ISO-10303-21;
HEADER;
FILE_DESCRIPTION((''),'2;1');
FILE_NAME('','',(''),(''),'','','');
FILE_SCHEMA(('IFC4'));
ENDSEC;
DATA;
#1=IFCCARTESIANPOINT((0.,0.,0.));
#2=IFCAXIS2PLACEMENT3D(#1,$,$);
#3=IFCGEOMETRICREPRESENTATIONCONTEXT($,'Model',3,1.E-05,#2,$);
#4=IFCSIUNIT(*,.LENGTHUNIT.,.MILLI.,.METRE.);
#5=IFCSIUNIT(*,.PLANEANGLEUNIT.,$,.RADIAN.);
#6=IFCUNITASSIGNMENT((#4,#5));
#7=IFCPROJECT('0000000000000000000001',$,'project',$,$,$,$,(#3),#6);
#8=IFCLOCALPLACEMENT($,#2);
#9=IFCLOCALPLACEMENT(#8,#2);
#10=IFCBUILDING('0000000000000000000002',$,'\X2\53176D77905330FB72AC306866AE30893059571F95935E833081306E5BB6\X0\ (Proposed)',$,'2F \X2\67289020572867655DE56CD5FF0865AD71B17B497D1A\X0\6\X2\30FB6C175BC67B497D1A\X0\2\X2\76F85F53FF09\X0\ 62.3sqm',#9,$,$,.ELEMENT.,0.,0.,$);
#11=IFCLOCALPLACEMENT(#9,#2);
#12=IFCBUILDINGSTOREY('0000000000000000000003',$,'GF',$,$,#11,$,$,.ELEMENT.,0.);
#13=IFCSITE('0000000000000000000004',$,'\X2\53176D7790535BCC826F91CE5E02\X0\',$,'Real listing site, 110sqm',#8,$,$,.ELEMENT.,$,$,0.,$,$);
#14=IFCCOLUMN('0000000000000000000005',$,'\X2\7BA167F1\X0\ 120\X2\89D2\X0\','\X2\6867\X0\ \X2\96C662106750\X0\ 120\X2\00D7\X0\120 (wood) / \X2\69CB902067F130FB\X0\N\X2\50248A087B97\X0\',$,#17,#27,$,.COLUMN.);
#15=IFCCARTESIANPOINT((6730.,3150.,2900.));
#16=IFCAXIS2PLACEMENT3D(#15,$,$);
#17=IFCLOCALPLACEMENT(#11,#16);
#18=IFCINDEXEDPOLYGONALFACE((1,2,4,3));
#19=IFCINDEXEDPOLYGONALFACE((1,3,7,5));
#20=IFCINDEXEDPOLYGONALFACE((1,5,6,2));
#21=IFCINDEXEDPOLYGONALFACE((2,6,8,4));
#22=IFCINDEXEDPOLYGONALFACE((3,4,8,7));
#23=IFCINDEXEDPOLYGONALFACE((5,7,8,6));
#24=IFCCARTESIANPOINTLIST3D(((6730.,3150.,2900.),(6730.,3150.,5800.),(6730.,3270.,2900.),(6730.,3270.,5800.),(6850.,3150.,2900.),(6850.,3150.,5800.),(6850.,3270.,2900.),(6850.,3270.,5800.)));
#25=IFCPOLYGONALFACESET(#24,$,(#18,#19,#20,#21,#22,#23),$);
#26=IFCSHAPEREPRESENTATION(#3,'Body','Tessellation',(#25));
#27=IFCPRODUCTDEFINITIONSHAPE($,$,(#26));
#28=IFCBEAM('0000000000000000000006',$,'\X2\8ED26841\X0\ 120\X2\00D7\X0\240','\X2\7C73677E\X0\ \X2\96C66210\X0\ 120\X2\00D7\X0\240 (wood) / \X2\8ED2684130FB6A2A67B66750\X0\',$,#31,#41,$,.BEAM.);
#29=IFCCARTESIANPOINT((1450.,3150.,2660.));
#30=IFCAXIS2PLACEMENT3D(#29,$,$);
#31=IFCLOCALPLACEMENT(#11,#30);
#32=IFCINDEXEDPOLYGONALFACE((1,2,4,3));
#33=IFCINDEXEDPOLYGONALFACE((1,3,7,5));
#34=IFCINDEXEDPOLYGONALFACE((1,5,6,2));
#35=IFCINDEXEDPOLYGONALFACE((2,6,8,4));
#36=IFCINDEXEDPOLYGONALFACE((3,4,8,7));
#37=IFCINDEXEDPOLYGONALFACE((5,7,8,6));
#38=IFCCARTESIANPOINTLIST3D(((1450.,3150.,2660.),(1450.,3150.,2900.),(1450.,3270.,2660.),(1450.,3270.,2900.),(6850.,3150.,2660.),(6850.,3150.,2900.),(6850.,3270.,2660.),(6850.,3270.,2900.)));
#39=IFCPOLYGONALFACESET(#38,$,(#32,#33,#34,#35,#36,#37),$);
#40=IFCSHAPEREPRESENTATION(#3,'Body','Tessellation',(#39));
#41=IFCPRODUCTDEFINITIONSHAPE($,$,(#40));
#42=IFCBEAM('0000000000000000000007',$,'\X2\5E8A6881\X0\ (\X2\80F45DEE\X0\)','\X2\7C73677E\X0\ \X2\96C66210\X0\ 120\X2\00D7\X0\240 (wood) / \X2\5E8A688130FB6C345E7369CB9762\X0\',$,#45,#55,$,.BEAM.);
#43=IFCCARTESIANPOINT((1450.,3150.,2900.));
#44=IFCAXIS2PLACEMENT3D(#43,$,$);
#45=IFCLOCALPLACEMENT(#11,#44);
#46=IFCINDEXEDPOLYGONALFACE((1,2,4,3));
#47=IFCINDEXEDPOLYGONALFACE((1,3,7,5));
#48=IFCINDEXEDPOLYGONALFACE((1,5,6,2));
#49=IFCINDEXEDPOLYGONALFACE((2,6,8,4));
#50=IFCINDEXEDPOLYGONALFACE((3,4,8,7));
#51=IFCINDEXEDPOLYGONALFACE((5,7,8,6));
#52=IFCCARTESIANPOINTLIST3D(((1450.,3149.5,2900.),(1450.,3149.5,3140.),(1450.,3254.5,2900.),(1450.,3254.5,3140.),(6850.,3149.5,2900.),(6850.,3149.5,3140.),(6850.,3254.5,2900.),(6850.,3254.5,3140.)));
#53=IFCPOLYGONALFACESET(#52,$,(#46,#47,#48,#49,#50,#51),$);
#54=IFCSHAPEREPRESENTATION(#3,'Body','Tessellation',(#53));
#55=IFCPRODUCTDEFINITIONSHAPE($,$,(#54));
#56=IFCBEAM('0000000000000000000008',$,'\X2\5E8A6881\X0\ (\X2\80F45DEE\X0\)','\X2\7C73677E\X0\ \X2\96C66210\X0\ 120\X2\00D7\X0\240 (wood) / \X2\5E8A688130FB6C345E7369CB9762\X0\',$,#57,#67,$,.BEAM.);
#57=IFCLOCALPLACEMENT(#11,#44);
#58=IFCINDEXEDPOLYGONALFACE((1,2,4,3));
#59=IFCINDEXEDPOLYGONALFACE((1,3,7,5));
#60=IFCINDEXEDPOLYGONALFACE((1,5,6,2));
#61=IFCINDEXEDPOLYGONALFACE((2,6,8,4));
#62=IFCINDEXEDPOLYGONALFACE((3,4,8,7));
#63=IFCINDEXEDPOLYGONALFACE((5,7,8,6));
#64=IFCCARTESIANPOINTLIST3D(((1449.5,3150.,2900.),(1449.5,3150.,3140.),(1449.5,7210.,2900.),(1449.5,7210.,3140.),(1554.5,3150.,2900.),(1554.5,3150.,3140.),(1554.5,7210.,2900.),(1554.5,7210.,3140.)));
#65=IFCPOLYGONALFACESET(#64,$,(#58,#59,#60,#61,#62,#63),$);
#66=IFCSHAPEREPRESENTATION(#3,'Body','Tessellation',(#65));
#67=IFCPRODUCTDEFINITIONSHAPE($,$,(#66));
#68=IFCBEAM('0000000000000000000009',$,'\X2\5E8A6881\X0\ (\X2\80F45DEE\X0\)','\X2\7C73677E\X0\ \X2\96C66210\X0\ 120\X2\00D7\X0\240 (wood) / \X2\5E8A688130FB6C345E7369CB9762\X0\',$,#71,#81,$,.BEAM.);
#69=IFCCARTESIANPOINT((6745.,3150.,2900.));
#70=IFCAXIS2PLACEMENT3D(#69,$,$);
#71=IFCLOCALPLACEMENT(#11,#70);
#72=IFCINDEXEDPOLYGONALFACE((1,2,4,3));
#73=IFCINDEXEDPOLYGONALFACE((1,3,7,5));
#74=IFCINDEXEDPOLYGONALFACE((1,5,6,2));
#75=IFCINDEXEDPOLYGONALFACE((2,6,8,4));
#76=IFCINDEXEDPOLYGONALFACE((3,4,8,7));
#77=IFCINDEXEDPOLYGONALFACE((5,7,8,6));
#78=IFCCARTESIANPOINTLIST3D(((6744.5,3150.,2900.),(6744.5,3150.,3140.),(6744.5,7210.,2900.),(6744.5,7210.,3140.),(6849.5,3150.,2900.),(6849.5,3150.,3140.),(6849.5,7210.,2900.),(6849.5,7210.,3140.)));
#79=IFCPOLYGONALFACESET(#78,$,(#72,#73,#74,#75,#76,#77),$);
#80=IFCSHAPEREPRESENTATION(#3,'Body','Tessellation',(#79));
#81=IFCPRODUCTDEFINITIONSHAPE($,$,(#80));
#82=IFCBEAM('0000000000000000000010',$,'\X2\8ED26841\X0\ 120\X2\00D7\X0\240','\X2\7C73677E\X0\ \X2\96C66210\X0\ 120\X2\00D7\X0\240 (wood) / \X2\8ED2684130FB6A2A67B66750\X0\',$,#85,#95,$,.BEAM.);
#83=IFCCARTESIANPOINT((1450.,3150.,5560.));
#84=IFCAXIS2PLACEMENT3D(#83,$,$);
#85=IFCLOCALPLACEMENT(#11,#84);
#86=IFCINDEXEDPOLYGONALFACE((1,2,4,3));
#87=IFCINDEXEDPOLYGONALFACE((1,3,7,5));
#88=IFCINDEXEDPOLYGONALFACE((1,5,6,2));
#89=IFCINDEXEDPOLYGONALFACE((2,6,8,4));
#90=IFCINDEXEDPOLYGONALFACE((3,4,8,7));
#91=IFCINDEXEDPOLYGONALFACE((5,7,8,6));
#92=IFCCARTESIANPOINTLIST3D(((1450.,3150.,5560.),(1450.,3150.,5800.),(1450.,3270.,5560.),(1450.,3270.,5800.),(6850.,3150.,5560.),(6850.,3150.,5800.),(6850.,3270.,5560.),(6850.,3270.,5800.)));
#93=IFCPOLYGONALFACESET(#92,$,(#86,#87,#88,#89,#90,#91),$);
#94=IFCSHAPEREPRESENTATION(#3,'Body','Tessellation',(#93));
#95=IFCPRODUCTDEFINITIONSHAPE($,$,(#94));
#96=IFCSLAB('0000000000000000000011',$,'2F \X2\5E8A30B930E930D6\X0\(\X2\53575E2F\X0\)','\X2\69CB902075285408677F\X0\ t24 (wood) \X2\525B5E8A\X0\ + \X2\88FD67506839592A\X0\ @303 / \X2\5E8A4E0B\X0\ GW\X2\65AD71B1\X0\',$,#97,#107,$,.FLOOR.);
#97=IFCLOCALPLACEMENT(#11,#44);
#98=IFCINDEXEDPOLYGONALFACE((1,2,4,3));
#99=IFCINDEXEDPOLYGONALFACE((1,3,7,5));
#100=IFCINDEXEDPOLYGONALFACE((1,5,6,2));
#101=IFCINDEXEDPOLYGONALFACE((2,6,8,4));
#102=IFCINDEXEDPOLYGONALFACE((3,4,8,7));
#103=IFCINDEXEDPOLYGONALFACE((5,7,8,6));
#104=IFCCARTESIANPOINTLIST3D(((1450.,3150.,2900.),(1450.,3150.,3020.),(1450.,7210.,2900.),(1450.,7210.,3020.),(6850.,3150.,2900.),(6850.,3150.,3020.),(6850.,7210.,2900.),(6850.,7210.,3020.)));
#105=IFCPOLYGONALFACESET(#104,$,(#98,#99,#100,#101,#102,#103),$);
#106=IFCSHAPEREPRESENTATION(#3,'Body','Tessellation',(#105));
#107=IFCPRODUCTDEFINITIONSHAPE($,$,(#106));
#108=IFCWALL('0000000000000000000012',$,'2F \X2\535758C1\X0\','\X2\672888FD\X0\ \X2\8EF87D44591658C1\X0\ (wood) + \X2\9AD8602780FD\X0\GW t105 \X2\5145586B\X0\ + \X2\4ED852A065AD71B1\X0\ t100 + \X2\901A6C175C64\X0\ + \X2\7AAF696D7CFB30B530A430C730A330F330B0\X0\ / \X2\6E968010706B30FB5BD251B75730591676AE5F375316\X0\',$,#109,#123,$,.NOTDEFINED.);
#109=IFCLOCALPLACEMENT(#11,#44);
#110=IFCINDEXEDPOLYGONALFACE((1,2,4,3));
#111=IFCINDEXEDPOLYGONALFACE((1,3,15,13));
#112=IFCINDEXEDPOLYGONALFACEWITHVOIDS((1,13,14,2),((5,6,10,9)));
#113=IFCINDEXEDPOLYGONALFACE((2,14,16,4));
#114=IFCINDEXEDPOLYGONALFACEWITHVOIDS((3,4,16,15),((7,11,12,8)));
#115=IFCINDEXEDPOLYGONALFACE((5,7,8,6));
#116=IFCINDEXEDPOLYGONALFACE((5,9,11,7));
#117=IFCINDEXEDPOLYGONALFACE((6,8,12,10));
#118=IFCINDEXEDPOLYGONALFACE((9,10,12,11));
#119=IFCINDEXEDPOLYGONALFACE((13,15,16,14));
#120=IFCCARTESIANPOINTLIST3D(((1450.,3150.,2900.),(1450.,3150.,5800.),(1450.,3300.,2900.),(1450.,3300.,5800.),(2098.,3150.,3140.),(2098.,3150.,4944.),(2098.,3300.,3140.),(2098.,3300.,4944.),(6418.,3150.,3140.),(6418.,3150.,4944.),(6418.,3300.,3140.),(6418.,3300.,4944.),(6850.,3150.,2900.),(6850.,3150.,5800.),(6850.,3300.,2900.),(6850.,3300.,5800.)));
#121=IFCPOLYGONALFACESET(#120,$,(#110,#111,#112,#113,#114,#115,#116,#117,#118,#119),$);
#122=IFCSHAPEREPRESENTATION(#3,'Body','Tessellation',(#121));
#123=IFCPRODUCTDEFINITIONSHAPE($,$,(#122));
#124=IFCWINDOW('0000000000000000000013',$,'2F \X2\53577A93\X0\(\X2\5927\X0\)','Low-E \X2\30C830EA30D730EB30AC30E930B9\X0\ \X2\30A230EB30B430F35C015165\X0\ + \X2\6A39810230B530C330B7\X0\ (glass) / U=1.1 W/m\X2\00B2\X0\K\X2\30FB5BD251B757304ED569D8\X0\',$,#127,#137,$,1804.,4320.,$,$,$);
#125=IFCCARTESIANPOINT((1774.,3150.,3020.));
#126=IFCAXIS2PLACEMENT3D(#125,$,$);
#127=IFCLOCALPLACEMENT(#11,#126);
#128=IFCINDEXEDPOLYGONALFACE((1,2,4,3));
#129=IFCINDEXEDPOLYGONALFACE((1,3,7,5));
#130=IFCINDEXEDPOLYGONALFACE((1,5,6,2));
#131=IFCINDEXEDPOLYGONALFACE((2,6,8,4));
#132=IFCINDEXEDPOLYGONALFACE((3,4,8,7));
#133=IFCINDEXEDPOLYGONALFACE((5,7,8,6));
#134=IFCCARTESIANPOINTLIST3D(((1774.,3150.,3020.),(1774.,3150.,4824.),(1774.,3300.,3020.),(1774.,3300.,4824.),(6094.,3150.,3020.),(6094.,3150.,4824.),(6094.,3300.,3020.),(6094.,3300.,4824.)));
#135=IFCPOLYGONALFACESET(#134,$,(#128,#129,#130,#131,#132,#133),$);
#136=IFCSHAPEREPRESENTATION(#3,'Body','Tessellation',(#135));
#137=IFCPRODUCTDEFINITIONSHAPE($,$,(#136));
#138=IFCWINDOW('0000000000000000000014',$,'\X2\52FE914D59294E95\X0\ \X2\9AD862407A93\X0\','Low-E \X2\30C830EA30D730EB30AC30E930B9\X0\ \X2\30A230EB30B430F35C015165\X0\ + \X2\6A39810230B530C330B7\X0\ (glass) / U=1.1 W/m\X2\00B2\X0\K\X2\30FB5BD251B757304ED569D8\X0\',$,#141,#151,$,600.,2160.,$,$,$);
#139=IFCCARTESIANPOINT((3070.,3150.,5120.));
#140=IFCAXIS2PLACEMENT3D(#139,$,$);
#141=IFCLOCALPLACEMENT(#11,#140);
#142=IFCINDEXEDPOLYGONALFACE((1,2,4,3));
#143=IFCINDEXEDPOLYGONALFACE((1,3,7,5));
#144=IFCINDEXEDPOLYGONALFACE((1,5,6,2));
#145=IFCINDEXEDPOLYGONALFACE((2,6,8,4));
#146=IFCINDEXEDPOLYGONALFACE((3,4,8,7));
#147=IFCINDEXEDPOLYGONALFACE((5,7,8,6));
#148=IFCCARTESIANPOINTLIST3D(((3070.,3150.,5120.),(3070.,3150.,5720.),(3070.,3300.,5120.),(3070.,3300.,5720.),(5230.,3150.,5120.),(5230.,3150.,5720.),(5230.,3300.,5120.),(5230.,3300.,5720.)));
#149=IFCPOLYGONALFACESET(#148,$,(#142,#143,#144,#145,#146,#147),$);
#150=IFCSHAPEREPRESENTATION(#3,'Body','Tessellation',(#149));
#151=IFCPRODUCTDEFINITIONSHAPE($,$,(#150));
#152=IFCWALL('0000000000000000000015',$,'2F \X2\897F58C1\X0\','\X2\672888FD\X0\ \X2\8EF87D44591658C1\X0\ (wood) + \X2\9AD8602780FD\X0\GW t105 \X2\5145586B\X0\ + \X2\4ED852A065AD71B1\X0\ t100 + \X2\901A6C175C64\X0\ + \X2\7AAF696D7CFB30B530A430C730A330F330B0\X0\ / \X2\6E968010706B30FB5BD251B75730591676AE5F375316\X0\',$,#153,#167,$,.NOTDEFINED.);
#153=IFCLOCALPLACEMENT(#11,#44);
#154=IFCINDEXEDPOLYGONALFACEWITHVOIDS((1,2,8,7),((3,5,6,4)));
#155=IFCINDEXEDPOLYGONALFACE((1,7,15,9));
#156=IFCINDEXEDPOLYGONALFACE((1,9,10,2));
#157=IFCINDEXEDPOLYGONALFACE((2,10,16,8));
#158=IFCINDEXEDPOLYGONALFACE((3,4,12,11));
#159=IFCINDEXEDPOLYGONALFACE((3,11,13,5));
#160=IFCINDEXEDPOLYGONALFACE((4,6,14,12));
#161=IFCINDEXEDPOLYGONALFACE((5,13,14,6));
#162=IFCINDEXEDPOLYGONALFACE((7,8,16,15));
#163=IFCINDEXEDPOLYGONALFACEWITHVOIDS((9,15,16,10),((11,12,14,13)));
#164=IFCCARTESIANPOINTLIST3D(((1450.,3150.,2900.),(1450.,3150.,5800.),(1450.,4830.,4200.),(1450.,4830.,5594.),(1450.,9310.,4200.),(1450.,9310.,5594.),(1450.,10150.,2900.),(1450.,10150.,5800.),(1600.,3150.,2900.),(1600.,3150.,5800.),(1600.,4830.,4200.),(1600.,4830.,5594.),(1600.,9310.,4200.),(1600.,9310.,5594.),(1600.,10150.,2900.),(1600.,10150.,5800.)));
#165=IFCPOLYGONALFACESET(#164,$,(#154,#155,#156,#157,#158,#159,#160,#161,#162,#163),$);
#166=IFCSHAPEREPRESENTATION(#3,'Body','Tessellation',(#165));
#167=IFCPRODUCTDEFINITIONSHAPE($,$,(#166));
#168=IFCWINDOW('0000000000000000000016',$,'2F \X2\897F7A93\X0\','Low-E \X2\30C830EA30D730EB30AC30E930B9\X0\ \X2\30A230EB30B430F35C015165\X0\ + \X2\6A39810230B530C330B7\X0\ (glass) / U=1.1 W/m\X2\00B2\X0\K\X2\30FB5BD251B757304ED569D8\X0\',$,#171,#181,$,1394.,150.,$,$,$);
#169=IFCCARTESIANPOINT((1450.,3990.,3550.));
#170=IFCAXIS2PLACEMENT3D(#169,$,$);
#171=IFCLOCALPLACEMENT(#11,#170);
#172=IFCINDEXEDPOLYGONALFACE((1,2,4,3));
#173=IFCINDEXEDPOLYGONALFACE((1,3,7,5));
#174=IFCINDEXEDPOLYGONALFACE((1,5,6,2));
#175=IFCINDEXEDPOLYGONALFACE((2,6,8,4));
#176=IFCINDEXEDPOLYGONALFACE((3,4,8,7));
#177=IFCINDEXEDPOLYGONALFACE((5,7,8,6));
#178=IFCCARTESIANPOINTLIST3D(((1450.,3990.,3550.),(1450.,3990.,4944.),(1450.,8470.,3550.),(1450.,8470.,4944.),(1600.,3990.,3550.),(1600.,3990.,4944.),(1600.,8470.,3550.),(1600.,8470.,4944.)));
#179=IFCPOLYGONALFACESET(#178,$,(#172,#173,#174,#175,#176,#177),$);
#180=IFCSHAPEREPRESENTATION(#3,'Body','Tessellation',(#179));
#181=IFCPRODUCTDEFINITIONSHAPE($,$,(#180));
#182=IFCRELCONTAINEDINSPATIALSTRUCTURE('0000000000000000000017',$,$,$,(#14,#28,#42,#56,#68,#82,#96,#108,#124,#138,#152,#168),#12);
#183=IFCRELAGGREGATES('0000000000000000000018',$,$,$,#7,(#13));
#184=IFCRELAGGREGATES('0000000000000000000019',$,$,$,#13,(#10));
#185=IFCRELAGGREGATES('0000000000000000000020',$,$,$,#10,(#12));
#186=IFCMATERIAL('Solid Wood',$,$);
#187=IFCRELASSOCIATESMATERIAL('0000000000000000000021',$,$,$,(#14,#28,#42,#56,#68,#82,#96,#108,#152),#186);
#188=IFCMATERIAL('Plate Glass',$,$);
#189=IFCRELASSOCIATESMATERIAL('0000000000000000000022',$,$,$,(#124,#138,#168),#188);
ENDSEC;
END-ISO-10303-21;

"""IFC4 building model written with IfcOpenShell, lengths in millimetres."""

from ifc_helpers import new_model, si_unit, frame, frame_2d, origin, place, context, project, spatial, rectangle, extrude, material, element, fill, save


model = new_model("IFC4")

# Units and contexts
model_context = context("Model", 3, precision=1e-05, world=origin())
ifc_project = project(units=[si_unit("LENGTHUNIT", "METRE", prefix="MILLI"), si_unit("PLANEANGLEUNIT", "RADIAN")], contexts=[model_context])

# Site, building, storey
site_placement = place(None, origin())
site = spatial("IfcSite", under=ifc_project, at=site_placement, Name="北海道富良野市", ObjectType="Real listing site, 110sqm", CompositionType="ELEMENT", RefElevation=0.0)
building_placement = place(site_placement, origin())
building = spatial("IfcBuilding", under=site, at=building_placement, Name="北海道・犬と暮らす土間広めの家 (Proposed)", ObjectType="2F 木造在来工法（断熱等級6・気密等級2相当） 62.3sqm", CompositionType="ELEMENT", ElevationOfRefHeight=0.0, ElevationOfTerrain=0.0)
storey_placement = place(building_placement, origin())
storey = spatial("IfcBuildingStorey", under=building, at=storey_placement, Name="GF", CompositionType="ELEMENT", Elevation=0.0)

# Column
ifc_material_1 = material(Name="Solid Wood")
column_1_placement = place(storey_placement, frame((6730.0, 3150.0, 2900.0)))
element("IfcColumn", 1, at=column_1_placement, inside=storey, material=ifc_material_1, Name="管柱 120角", Description="桧 集成材 120×120 (wood) / 構造柱・N値計算", PredefinedType="COLUMN", context=model_context, shape_type="SweptSolid", body=[
    extrude(rectangle(XDim=120.0, YDim=120.0, at=frame_2d((60.0, 60.0))), frame((6730.0, 3150.0, 2900.0)), (0.0, 0.0, 1.0), 2900.0),
])

# Beams
beam_1_placement = place(storey_placement, frame((1450.0, 3150.0, 2660.0)))
element("IfcBeam", 2, at=beam_1_placement, inside=storey, material=ifc_material_1, Name="軒桁 120×240", Description="米松 集成 120×240 (wood) / 軒桁・横架材", PredefinedType="BEAM", context=model_context, shape_type="SweptSolid", body=[
    extrude(rectangle(XDim=5400.0, YDim=120.0, at=frame_2d((2700.0, 60.0))), frame((1450.0, 3150.0, 2660.0)), (0.0, 0.0, 1.0), 240.0),
])
beam_2_placement = place(storey_placement, frame((1450.0, 3150.0, 2900.0)))
element("IfcBeam", 3, at=beam_2_placement, inside=storey, material=ifc_material_1, Name="床梁 (胴差)", Description="米松 集成 120×240 (wood) / 床梁・水平構面", PredefinedType="BEAM", context=model_context, shape_type="SweptSolid", body=[
    extrude(rectangle(XDim=5400.0, YDim=105.0, at=frame_2d((2700.0, 52.0))), frame((1450.0, 3150.0, 2900.0)), (0.0, 0.0, 1.0), 240.0),
])
beam_3_placement = place(storey_placement, frame((1450.0, 3150.0, 2900.0)))
element("IfcBeam", 4, at=beam_3_placement, inside=storey, material=ifc_material_1, Name="床梁 (胴差)", Description="米松 集成 120×240 (wood) / 床梁・水平構面", PredefinedType="BEAM", context=model_context, shape_type="SweptSolid", body=[
    extrude(rectangle(XDim=105.0, YDim=4060.0, at=frame_2d((52.0, 2030.0))), frame((1450.0, 3150.0, 2900.0)), (0.0, 0.0, 1.0), 240.0),
])
beam_4_placement = place(storey_placement, frame((6745.0, 3150.0, 2900.0)))
element("IfcBeam", 5, at=beam_4_placement, inside=storey, material=ifc_material_1, Name="床梁 (胴差)", Description="米松 集成 120×240 (wood) / 床梁・水平構面", PredefinedType="BEAM", context=model_context, shape_type="SweptSolid", body=[
    extrude(rectangle(XDim=105.0, YDim=4060.0, at=frame_2d((52.0, 2030.0))), frame((6745.0, 3150.0, 2900.0)), (0.0, 0.0, 1.0), 240.0),
])
beam_5_placement = place(storey_placement, frame((1450.0, 3150.0, 5560.0)))
element("IfcBeam", 6, at=beam_5_placement, inside=storey, material=ifc_material_1, Name="軒桁 120×240", Description="米松 集成 120×240 (wood) / 軒桁・横架材", PredefinedType="BEAM", context=model_context, shape_type="SweptSolid", body=[
    extrude(rectangle(XDim=5400.0, YDim=120.0, at=frame_2d((2700.0, 60.0))), frame((1450.0, 3150.0, 5560.0)), (0.0, 0.0, 1.0), 240.0),
])

# Slab
slab_placement = place(storey_placement, frame((1450.0, 3150.0, 2900.0)))
element("IfcSlab", 7, at=slab_placement, inside=storey, material=ifc_material_1, Name="2F 床スラブ(南帯)", Description="構造用合板 t24 (wood) 剛床 + 製材根太 @303 / 床下 GW断熱", PredefinedType="FLOOR", context=model_context, shape_type="SweptSolid", body=[
    extrude(rectangle(XDim=5400.0, YDim=4060.0, at=frame_2d((2700.0, 2030.0))), frame((1450.0, 3150.0, 2900.0)), (0.0, 0.0, 1.0), 120.0),
])

# Wall, openings, windows
wall_1_placement = place(storey_placement, frame((1450.0, 3150.0, 2900.0)))
wall_1 = element("IfcWall", 8, at=wall_1_placement, inside=storey, material=ifc_material_1, Name="2F 南壁", Description="木製 軸組外壁 (wood) + 高性能GW t105 充填 + 付加断熱 t100 + 通気層 + 窯業系サイディング / 準耐火・寒冷地外皮強化", PredefinedType="NOTDEFINED", context=model_context, shape_type="SweptSolid", body=[
    extrude(rectangle(XDim=5400.0, YDim=150.0, at=frame_2d((2700.0, 75.0))), frame((1450.0, 3150.0, 2900.0)), (0.0, 0.0, 1.0), 2900.0),
])
opening_1_placement = place(storey_placement, frame((1774.0, 3150.0, 3020.0)))
opening_1 = element("IfcOpeningElement", 9, at=opening_1_placement, cuts=wall_1, PredefinedType="NOTDEFINED", context=model_context, shape_type="SweptSolid", body=[
    extrude(rectangle(XDim=4320.0, YDim=150.0, at=frame_2d((2160.0, 75.0))), frame((1774.0, 3150.0, 3020.0)), (0.0, 0.0, 1.0), 1804.0),
])
opening_2_placement = place(storey_placement, frame((3070.0, 3150.0, 5120.0)))
opening_2 = element("IfcOpeningElement", 10, at=opening_2_placement, cuts=wall_1, PredefinedType="NOTDEFINED", context=model_context, shape_type="SweptSolid", body=[
    extrude(rectangle(XDim=2160.0, YDim=150.0, at=frame_2d((1080.0, 75.0))), frame((3070.0, 3150.0, 5120.0)), (0.0, 0.0, 1.0), 600.0),
])
ifc_material_2 = material(Name="Plate Glass")
window_1_placement = place(storey_placement, frame((1774.0, 3150.0, 3020.0)))
window_1 = element("IfcWindow", 11, at=window_1_placement, inside=storey, material=ifc_material_2, Name="2F 南窓(大)", Description="Low-E トリプルガラス アルゴン封入 + 樹脂サッシ (glass) / U=1.1 W/m²K・寒冷地仕様", OverallHeight=1804.0, OverallWidth=4320.0, context=model_context, shape_type="SweptSolid", body=[
    extrude(rectangle(XDim=4320.0, YDim=150.0, at=frame_2d((2160.0, 75.0))), frame((1774.0, 3150.0, 3020.0)), (0.0, 0.0, 1.0), 1804.0),
])
fill(opening_1, window_1)
window_2_placement = place(storey_placement, frame((3070.0, 3150.0, 5120.0)))
window_2 = element("IfcWindow", 12, at=window_2_placement, inside=storey, material=ifc_material_2, Name="勾配天井 高所窓", Description="Low-E トリプルガラス アルゴン封入 + 樹脂サッシ (glass) / U=1.1 W/m²K・寒冷地仕様", OverallHeight=600.0, OverallWidth=2160.0, context=model_context, shape_type="SweptSolid", body=[
    extrude(rectangle(XDim=2160.0, YDim=150.0, at=frame_2d((1080.0, 75.0))), frame((3070.0, 3150.0, 5120.0)), (0.0, 0.0, 1.0), 600.0),
])
fill(opening_2, window_2)

# Wall, opening, window
wall_2_placement = place(storey_placement, frame((1450.0, 3150.0, 2900.0)))
wall_2 = element("IfcWall", 13, at=wall_2_placement, inside=storey, material=ifc_material_1, Name="2F 西壁", Description="木製 軸組外壁 (wood) + 高性能GW t105 充填 + 付加断熱 t100 + 通気層 + 窯業系サイディング / 準耐火・寒冷地外皮強化", PredefinedType="NOTDEFINED", context=model_context, shape_type="SweptSolid", body=[
    extrude(rectangle(XDim=150.0, YDim=7000.0, at=frame_2d((75.0, 3500.0))), frame((1450.0, 3150.0, 2900.0)), (0.0, 0.0, 1.0), 2900.0),
])
opening_3_placement = place(storey_placement, frame((1450.0, 3990.0, 3550.0)))
opening_3 = element("IfcOpeningElement", 14, at=opening_3_placement, cuts=wall_2, PredefinedType="NOTDEFINED", context=model_context, shape_type="SweptSolid", body=[
    extrude(rectangle(XDim=150.0, YDim=4480.0, at=frame_2d((75.0, 2240.0))), frame((1450.0, 3990.0, 3550.0)), (0.0, 0.0, 1.0), 1394.0),
])
window_3_placement = place(storey_placement, frame((1450.0, 3990.0, 3550.0)))
window_3 = element("IfcWindow", 15, at=window_3_placement, inside=storey, material=ifc_material_2, Name="2F 西窓", Description="Low-E トリプルガラス アルゴン封入 + 樹脂サッシ (glass) / U=1.1 W/m²K・寒冷地仕様", OverallHeight=1394.0, OverallWidth=150.0, context=model_context, shape_type="SweptSolid", body=[
    extrude(rectangle(XDim=150.0, YDim=4480.0, at=frame_2d((75.0, 2240.0))), frame((1450.0, 3990.0, 3550.0)), (0.0, 0.0, 1.0), 1394.0),
])
fill(opening_3, window_3)

save(model, "model.ifc")
